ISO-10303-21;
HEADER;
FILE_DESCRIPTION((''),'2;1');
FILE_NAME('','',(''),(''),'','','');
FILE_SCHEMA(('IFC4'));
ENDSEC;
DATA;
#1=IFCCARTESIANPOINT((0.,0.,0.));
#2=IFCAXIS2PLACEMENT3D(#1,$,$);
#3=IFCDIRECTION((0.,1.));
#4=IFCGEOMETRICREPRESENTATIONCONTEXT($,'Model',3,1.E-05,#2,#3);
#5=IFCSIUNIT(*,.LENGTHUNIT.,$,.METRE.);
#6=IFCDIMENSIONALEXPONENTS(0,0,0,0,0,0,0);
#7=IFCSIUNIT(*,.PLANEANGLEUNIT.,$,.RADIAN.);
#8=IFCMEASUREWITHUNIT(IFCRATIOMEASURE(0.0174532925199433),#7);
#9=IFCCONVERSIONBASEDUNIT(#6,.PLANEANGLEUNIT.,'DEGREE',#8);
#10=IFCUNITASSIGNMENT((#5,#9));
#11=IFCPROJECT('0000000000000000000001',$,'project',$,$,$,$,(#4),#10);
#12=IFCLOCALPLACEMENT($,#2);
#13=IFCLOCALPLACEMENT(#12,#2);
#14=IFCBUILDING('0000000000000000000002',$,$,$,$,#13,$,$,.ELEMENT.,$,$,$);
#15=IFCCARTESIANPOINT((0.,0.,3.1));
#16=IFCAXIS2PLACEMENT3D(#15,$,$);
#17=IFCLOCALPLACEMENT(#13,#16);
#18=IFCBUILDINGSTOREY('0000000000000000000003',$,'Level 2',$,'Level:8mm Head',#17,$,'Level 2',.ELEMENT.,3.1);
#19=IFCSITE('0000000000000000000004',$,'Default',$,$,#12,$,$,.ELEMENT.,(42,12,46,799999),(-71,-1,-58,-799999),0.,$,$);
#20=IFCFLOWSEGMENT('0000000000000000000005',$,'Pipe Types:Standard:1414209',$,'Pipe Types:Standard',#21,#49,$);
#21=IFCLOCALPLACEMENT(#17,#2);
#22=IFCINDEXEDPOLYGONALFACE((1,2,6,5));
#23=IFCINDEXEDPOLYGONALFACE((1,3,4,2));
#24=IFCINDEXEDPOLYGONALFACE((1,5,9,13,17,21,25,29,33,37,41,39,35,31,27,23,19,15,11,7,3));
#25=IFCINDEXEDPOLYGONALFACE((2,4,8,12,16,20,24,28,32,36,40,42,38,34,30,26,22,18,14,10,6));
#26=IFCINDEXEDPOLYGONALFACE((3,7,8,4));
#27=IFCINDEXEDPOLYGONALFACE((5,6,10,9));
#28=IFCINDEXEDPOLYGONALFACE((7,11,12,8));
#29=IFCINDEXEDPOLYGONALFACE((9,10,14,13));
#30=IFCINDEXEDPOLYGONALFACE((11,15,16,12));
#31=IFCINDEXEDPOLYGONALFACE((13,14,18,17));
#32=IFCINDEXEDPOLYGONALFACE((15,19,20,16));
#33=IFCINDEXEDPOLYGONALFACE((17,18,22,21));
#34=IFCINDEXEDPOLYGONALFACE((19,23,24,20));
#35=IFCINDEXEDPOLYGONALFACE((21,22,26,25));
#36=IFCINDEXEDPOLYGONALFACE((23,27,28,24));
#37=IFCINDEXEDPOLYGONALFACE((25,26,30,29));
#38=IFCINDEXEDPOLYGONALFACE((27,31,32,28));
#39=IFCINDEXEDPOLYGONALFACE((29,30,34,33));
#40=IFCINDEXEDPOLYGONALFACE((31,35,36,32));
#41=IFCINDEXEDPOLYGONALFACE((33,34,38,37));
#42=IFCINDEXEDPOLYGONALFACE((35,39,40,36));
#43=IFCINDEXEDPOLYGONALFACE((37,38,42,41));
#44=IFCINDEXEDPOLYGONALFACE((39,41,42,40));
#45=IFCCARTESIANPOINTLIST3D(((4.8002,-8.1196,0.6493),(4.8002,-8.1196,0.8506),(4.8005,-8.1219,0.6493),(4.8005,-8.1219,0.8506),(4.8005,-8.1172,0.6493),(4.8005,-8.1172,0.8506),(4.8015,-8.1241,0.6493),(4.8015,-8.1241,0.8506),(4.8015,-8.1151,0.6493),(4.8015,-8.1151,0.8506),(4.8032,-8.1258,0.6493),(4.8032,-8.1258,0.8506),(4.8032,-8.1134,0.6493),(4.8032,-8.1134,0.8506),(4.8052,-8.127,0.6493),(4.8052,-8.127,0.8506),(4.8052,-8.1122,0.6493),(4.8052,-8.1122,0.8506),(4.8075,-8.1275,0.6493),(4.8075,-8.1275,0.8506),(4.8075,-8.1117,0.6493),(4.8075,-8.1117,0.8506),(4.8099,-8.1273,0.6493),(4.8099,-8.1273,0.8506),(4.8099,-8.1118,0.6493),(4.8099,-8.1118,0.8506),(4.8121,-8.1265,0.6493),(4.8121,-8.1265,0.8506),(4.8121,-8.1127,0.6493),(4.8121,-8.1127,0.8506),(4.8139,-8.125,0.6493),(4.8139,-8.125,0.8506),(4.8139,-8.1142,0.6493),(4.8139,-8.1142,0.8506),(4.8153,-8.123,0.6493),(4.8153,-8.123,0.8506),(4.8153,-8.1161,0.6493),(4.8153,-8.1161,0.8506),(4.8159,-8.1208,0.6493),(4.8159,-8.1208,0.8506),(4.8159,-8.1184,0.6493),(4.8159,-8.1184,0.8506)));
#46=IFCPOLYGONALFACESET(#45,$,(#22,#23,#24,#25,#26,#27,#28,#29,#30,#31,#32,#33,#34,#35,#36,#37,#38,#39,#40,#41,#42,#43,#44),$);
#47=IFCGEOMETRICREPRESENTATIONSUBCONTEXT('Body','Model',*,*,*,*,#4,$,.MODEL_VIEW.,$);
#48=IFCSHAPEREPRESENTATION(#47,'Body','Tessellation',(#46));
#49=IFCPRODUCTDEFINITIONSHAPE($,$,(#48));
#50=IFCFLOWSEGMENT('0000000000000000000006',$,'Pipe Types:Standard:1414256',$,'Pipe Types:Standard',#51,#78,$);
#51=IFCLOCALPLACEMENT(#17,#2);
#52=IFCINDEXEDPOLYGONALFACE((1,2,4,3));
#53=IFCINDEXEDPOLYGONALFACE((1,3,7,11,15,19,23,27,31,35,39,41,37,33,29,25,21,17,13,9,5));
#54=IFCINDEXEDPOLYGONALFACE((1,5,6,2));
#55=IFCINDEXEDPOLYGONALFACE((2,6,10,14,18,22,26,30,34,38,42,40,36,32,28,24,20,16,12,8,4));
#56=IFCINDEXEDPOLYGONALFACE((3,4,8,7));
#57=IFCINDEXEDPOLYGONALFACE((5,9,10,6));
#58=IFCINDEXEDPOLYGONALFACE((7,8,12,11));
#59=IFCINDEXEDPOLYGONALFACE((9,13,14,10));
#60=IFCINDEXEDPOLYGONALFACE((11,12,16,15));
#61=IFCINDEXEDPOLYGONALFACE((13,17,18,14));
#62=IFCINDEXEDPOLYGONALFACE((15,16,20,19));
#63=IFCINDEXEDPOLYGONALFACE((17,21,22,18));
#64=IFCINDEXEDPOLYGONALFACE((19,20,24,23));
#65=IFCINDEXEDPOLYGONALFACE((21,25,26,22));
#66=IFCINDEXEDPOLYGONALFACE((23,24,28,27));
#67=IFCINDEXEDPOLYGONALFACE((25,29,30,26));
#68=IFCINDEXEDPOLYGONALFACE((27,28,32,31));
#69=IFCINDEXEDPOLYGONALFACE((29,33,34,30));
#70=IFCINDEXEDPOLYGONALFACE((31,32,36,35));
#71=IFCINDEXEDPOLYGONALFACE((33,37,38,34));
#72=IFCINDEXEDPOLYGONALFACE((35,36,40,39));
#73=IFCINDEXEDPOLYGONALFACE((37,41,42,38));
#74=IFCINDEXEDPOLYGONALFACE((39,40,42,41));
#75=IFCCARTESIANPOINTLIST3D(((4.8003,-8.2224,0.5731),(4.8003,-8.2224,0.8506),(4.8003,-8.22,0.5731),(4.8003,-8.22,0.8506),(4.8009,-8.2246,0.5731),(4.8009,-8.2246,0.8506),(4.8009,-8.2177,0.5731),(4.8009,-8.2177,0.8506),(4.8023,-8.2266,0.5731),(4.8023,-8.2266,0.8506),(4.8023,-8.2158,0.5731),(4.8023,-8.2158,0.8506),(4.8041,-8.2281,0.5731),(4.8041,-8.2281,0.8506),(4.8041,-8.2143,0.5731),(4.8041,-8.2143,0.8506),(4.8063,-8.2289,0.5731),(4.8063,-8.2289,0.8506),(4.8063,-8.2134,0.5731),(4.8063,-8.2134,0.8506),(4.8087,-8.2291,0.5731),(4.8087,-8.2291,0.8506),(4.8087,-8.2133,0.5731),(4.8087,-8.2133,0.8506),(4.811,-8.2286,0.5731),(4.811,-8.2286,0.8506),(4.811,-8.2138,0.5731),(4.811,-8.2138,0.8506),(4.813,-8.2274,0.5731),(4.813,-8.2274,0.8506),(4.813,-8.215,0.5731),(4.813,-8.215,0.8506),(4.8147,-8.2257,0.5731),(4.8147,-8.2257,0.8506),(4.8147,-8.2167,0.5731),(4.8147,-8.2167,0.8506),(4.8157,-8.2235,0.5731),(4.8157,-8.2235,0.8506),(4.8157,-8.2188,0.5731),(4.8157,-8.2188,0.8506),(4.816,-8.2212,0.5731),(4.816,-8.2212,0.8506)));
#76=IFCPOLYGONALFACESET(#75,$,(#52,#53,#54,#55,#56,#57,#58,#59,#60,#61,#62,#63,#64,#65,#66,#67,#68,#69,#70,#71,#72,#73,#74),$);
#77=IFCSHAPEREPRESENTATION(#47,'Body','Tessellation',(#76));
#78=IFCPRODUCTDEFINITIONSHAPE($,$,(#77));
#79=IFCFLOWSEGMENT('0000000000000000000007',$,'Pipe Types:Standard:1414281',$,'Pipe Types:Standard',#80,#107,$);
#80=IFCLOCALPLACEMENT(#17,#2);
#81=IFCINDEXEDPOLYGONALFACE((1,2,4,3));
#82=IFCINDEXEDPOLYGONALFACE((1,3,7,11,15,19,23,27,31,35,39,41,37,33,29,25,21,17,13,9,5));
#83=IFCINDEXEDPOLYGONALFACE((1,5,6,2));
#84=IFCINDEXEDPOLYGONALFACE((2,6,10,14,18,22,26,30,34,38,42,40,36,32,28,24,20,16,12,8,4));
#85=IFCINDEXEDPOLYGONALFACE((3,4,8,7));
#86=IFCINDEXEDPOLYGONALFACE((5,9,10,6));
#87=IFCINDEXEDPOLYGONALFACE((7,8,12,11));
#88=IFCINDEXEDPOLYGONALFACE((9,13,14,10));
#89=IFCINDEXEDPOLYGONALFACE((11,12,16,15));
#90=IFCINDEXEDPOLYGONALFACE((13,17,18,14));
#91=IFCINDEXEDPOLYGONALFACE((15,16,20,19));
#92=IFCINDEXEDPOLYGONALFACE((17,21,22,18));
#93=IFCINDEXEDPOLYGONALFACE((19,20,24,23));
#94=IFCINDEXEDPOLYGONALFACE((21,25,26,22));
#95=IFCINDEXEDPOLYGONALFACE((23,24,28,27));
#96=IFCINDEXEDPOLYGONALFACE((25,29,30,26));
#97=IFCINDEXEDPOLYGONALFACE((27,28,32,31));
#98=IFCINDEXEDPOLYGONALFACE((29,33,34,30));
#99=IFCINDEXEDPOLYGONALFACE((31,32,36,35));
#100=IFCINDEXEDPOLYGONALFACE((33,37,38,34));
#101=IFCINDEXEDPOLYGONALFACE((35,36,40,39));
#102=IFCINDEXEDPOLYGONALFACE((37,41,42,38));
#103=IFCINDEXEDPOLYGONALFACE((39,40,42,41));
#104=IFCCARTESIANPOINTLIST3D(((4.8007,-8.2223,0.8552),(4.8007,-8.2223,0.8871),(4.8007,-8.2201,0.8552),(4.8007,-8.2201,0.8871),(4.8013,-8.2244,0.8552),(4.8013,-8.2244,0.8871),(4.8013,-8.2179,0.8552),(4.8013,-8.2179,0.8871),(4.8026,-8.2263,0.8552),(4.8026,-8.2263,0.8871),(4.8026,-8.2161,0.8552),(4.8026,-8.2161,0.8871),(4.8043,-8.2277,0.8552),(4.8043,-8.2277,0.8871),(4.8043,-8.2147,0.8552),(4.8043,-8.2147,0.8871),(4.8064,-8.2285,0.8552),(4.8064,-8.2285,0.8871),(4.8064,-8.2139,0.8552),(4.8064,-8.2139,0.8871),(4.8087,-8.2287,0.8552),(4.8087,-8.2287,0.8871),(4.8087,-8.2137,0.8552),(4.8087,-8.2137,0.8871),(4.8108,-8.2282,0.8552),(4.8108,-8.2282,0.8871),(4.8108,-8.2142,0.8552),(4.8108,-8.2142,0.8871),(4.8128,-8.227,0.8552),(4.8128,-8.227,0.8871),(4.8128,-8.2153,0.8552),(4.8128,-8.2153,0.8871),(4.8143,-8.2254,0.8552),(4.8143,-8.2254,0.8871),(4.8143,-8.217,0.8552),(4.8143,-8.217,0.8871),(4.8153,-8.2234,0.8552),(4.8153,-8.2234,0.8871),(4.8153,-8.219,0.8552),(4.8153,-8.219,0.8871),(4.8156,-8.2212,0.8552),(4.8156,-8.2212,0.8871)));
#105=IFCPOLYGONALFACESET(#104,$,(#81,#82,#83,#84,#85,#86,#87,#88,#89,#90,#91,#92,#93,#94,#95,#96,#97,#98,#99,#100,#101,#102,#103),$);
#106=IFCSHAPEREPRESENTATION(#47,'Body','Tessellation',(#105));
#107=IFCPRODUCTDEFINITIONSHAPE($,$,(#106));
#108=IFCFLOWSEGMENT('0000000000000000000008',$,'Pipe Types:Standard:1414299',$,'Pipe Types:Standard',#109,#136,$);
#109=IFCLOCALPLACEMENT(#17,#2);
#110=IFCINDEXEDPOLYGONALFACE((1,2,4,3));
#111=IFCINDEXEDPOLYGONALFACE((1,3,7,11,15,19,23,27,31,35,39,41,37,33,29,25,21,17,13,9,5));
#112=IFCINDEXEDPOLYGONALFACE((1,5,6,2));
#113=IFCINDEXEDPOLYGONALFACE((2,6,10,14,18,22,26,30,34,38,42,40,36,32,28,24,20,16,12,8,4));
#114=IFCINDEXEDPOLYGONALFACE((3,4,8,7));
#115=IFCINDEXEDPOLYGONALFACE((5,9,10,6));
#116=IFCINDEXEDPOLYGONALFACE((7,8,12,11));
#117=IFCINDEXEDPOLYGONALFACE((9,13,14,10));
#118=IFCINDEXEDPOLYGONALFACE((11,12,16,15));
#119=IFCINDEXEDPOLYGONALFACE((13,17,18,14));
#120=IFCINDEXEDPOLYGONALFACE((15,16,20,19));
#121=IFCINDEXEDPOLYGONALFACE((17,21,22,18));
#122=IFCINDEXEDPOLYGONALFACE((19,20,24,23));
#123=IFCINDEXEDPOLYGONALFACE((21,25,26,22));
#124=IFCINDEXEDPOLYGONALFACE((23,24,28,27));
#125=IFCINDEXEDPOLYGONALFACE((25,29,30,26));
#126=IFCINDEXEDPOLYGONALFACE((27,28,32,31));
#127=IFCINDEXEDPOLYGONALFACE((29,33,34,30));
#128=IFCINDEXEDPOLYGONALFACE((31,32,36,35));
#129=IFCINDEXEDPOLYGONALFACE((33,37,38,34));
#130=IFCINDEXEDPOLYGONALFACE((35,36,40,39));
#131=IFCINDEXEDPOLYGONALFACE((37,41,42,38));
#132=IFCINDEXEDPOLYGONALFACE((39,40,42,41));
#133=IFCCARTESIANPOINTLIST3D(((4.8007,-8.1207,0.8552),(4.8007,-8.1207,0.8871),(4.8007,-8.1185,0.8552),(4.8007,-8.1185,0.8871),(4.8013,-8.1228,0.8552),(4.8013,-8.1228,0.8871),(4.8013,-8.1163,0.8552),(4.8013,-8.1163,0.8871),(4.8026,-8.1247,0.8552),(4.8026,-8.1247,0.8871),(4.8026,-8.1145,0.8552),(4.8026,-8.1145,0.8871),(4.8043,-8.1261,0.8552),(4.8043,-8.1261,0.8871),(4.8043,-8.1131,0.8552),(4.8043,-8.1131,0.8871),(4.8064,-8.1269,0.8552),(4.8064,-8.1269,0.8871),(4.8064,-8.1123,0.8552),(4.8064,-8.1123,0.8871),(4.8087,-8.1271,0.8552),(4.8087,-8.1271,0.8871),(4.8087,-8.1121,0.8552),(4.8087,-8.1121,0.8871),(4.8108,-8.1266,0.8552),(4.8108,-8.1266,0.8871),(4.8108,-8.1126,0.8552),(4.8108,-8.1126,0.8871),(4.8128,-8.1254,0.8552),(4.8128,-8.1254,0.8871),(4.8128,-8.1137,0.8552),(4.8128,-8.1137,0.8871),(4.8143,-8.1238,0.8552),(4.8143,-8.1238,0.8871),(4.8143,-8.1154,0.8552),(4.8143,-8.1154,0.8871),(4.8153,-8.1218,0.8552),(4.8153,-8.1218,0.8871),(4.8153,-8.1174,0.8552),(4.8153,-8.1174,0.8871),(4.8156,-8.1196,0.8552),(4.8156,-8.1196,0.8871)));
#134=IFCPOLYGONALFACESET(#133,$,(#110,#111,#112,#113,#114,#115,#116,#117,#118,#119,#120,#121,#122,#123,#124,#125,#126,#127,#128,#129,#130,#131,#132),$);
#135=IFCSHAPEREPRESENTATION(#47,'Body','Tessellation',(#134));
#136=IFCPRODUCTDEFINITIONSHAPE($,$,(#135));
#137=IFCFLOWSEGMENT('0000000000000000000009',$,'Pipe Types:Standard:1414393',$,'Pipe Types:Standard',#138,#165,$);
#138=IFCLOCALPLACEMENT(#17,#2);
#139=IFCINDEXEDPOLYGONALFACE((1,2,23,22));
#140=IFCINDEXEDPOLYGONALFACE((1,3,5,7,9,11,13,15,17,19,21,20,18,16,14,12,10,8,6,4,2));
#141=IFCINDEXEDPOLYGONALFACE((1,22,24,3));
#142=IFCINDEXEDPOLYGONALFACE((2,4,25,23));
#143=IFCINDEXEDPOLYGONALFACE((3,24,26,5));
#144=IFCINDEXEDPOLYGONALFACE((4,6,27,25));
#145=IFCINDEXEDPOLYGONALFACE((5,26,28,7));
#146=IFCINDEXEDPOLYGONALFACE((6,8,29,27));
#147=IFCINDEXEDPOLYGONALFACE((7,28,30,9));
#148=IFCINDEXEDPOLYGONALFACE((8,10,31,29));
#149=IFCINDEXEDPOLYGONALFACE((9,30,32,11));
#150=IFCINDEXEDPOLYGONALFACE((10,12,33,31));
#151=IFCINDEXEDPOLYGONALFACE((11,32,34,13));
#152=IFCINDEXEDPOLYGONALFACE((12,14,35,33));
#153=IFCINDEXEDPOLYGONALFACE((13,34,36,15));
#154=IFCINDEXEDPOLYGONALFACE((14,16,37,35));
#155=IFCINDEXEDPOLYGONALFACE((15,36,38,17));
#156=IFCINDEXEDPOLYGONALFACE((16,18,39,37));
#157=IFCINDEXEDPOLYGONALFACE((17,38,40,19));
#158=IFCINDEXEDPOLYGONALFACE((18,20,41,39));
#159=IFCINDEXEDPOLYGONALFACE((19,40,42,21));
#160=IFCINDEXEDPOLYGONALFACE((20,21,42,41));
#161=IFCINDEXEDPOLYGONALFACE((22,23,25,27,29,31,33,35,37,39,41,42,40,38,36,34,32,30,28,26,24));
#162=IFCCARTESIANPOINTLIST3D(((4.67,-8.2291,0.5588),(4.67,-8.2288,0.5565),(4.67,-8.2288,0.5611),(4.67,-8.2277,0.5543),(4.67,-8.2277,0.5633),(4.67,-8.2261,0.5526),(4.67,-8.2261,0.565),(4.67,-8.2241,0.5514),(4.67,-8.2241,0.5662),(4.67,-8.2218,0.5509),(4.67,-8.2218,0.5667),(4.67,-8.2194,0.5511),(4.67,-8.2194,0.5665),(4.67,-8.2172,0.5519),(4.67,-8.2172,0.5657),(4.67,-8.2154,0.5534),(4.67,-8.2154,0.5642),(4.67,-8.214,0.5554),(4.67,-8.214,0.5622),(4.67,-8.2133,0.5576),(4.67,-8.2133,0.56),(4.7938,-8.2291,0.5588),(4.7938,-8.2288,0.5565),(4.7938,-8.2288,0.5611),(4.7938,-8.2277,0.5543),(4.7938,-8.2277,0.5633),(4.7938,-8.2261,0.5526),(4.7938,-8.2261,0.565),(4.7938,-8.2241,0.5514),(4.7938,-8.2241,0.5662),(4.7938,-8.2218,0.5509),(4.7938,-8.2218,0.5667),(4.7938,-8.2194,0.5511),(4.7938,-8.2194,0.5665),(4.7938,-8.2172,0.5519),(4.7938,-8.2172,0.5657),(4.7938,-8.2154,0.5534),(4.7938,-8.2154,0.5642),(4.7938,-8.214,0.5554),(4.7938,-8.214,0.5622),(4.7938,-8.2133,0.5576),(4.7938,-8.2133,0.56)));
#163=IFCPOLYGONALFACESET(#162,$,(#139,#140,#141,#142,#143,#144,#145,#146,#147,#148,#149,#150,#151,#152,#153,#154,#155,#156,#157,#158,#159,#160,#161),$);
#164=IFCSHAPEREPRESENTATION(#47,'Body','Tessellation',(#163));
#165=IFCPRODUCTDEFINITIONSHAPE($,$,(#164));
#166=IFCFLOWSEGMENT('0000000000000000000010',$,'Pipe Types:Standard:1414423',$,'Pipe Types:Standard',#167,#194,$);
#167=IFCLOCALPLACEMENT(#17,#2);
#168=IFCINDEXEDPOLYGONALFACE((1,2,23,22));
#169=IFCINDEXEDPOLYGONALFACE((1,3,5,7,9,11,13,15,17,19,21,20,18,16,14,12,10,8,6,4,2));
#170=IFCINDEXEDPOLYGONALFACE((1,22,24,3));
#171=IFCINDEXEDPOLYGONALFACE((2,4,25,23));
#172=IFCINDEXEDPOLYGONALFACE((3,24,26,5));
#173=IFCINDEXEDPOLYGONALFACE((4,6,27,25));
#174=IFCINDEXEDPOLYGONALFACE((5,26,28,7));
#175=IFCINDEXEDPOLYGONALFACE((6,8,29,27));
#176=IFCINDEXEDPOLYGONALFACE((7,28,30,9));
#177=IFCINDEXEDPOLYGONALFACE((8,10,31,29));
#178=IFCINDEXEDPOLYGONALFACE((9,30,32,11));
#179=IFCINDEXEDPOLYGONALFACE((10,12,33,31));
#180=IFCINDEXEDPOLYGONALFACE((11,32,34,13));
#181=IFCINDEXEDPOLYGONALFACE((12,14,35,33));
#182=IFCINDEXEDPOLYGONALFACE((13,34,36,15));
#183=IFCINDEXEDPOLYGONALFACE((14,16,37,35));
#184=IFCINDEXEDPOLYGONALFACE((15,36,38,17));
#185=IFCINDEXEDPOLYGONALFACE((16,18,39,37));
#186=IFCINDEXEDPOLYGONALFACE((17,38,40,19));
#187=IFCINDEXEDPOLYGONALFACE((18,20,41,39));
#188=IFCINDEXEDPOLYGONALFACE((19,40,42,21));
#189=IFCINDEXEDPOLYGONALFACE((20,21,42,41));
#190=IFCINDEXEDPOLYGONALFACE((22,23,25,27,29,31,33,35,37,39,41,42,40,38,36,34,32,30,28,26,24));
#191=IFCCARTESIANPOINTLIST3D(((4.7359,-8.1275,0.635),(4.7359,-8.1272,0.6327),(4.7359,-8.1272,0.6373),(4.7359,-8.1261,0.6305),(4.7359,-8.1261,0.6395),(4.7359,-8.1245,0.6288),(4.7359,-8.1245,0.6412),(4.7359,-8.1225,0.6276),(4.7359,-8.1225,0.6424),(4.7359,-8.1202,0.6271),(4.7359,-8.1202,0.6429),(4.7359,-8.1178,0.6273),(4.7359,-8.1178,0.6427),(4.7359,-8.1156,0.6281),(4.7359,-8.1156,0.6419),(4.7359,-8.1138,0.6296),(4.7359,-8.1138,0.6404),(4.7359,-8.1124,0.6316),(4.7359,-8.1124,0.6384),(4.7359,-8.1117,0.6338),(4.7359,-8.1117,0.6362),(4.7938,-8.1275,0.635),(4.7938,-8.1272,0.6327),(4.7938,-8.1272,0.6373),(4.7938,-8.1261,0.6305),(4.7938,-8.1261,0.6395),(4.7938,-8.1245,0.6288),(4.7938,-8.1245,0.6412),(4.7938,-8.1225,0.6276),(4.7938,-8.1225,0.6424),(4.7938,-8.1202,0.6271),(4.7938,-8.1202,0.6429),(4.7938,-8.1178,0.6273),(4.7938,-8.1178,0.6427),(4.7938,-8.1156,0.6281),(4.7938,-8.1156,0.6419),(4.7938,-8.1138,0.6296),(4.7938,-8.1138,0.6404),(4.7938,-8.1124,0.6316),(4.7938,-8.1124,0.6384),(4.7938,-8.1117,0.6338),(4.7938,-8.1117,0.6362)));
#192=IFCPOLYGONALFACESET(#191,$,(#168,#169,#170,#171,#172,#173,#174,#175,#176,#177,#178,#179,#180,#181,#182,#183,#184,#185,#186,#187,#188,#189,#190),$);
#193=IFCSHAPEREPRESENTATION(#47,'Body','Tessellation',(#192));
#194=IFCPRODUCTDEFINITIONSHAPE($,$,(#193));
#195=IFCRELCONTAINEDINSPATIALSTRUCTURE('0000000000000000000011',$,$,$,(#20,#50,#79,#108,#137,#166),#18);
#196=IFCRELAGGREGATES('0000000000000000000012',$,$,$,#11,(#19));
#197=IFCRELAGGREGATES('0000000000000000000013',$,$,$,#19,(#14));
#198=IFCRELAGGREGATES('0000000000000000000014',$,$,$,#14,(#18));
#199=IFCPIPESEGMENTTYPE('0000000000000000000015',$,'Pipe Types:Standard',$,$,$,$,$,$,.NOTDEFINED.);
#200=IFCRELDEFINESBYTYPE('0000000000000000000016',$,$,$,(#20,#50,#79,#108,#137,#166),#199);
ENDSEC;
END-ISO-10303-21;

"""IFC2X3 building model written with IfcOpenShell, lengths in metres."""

from ifc_helpers import new_model, entity, si_unit, converted_unit, direction, frame, origin, origin_2d_with_axis, place, context, subcontext, project, spatial, circle, extrude, type_object, element, save


model = new_model("IFC2X3")

# Units and contexts
model_context = context("Model", 3, precision=1e-05, world=origin(), true_north=direction((0.0, 1.0)))
body_context = subcontext(model_context, "Body", "Model", "MODEL_VIEW")
ifc_project = project(units=[si_unit("LENGTHUNIT", "METRE"), converted_unit("PLANEANGLEUNIT", "DEGREE", entity("IfcRatioMeasure", 0.0174532925199433), si_unit("PLANEANGLEUNIT", "RADIAN"), dimensions=[0, 0, 0, 0, 0, 0, 0])], contexts=[model_context])

# Site, building, storey
site_placement = place(None, origin())
site = spatial("IfcSite", under=ifc_project, at=site_placement, Name="Default", CompositionType="ELEMENT", RefLatitude=(42, 12, 46, 799999), RefLongitude=(-71, -1, -58, -799999), RefElevation=0.0)
building_placement = place(site_placement, origin())
building = spatial("IfcBuilding", under=site, at=building_placement, CompositionType="ELEMENT")
storey_placement = place(building_placement, frame((0.0, 0.0, 3.1)))
storey = spatial("IfcBuildingStorey", under=building, at=storey_placement, Name="Level 2", ObjectType="Level:8mm Head", LongName="Level 2", CompositionType="ELEMENT", Elevation=3.1)

# Flow segments
pipe_segment_type = type_object("IfcPipeSegmentType", Name="Pipe Types:Standard", PredefinedType="NOTDEFINED")
flow_segment_1_placement = place(storey_placement, origin())
element("IfcFlowSegment", 1, at=flow_segment_1_placement, inside=storey, type_object=pipe_segment_type, Name="Pipe Types:Standard:1414209", ObjectType="Pipe Types:Standard", context=body_context, shape_type="SweptSolid", body=[
    extrude(circle(Radius=0.0079, at=origin_2d_with_axis()), frame((4.8081, -8.1196, 0.6493), z_axis=(0.0, 0.0, 1.0), x_axis=(-1.0, 0.0, 0.0)), (0.0, 0.0, 1.0), 0.2013),
])
flow_segment_2_placement = place(storey_placement, origin())
element("IfcFlowSegment", 2, at=flow_segment_2_placement, inside=storey, type_object=pipe_segment_type, Name="Pipe Types:Standard:1414256", ObjectType="Pipe Types:Standard", context=body_context, shape_type="SweptSolid", body=[
    extrude(circle(Radius=0.0079, at=origin_2d_with_axis()), frame((4.8081, -8.2212, 0.5731)), (0.0, 0.0, 1.0), 0.2775),
])
flow_segment_3_placement = place(storey_placement, origin())
element("IfcFlowSegment", 3, at=flow_segment_3_placement, inside=storey, type_object=pipe_segment_type, Name="Pipe Types:Standard:1414281", ObjectType="Pipe Types:Standard", context=body_context, shape_type="SweptSolid", body=[
    extrude(circle(Radius=0.0075, at=origin_2d_with_axis()), frame((4.8081, -8.2212, 0.8552)), (0.0, 0.0, 1.0), 0.032),
])
flow_segment_4_placement = place(storey_placement, origin())
element("IfcFlowSegment", 4, at=flow_segment_4_placement, inside=storey, type_object=pipe_segment_type, Name="Pipe Types:Standard:1414299", ObjectType="Pipe Types:Standard", context=body_context, shape_type="SweptSolid", body=[
    extrude(circle(Radius=0.0075, at=origin_2d_with_axis()), frame((4.8081, -8.1196, 0.8552)), (0.0, 0.0, 1.0), 0.032),
])
flow_segment_5_placement = place(storey_placement, origin())
element("IfcFlowSegment", 5, at=flow_segment_5_placement, inside=storey, type_object=pipe_segment_type, Name="Pipe Types:Standard:1414393", ObjectType="Pipe Types:Standard", context=body_context, shape_type="SweptSolid", body=[
    extrude(circle(Radius=0.0079, at=origin_2d_with_axis()), frame((4.67, -8.2212, 0.5588), z_axis=(1.0, 0.0, 0.0), x_axis=(0.0, -1.0, 0.0)), (0.0, 0.0, 1.0), 0.1238),
])
flow_segment_6_placement = place(storey_placement, origin())
element("IfcFlowSegment", 6, at=flow_segment_6_placement, inside=storey, type_object=pipe_segment_type, Name="Pipe Types:Standard:1414423", ObjectType="Pipe Types:Standard", context=body_context, shape_type="SweptSolid", body=[
    extrude(circle(Radius=0.0079, at=origin_2d_with_axis()), frame((4.7359, -8.1196, 0.635), z_axis=(1.0, 0.0, 0.0), x_axis=(0.0, -1.0, 0.0)), (0.0, 0.0, 1.0), 0.0579),
])

save(model, "model.ifc")
